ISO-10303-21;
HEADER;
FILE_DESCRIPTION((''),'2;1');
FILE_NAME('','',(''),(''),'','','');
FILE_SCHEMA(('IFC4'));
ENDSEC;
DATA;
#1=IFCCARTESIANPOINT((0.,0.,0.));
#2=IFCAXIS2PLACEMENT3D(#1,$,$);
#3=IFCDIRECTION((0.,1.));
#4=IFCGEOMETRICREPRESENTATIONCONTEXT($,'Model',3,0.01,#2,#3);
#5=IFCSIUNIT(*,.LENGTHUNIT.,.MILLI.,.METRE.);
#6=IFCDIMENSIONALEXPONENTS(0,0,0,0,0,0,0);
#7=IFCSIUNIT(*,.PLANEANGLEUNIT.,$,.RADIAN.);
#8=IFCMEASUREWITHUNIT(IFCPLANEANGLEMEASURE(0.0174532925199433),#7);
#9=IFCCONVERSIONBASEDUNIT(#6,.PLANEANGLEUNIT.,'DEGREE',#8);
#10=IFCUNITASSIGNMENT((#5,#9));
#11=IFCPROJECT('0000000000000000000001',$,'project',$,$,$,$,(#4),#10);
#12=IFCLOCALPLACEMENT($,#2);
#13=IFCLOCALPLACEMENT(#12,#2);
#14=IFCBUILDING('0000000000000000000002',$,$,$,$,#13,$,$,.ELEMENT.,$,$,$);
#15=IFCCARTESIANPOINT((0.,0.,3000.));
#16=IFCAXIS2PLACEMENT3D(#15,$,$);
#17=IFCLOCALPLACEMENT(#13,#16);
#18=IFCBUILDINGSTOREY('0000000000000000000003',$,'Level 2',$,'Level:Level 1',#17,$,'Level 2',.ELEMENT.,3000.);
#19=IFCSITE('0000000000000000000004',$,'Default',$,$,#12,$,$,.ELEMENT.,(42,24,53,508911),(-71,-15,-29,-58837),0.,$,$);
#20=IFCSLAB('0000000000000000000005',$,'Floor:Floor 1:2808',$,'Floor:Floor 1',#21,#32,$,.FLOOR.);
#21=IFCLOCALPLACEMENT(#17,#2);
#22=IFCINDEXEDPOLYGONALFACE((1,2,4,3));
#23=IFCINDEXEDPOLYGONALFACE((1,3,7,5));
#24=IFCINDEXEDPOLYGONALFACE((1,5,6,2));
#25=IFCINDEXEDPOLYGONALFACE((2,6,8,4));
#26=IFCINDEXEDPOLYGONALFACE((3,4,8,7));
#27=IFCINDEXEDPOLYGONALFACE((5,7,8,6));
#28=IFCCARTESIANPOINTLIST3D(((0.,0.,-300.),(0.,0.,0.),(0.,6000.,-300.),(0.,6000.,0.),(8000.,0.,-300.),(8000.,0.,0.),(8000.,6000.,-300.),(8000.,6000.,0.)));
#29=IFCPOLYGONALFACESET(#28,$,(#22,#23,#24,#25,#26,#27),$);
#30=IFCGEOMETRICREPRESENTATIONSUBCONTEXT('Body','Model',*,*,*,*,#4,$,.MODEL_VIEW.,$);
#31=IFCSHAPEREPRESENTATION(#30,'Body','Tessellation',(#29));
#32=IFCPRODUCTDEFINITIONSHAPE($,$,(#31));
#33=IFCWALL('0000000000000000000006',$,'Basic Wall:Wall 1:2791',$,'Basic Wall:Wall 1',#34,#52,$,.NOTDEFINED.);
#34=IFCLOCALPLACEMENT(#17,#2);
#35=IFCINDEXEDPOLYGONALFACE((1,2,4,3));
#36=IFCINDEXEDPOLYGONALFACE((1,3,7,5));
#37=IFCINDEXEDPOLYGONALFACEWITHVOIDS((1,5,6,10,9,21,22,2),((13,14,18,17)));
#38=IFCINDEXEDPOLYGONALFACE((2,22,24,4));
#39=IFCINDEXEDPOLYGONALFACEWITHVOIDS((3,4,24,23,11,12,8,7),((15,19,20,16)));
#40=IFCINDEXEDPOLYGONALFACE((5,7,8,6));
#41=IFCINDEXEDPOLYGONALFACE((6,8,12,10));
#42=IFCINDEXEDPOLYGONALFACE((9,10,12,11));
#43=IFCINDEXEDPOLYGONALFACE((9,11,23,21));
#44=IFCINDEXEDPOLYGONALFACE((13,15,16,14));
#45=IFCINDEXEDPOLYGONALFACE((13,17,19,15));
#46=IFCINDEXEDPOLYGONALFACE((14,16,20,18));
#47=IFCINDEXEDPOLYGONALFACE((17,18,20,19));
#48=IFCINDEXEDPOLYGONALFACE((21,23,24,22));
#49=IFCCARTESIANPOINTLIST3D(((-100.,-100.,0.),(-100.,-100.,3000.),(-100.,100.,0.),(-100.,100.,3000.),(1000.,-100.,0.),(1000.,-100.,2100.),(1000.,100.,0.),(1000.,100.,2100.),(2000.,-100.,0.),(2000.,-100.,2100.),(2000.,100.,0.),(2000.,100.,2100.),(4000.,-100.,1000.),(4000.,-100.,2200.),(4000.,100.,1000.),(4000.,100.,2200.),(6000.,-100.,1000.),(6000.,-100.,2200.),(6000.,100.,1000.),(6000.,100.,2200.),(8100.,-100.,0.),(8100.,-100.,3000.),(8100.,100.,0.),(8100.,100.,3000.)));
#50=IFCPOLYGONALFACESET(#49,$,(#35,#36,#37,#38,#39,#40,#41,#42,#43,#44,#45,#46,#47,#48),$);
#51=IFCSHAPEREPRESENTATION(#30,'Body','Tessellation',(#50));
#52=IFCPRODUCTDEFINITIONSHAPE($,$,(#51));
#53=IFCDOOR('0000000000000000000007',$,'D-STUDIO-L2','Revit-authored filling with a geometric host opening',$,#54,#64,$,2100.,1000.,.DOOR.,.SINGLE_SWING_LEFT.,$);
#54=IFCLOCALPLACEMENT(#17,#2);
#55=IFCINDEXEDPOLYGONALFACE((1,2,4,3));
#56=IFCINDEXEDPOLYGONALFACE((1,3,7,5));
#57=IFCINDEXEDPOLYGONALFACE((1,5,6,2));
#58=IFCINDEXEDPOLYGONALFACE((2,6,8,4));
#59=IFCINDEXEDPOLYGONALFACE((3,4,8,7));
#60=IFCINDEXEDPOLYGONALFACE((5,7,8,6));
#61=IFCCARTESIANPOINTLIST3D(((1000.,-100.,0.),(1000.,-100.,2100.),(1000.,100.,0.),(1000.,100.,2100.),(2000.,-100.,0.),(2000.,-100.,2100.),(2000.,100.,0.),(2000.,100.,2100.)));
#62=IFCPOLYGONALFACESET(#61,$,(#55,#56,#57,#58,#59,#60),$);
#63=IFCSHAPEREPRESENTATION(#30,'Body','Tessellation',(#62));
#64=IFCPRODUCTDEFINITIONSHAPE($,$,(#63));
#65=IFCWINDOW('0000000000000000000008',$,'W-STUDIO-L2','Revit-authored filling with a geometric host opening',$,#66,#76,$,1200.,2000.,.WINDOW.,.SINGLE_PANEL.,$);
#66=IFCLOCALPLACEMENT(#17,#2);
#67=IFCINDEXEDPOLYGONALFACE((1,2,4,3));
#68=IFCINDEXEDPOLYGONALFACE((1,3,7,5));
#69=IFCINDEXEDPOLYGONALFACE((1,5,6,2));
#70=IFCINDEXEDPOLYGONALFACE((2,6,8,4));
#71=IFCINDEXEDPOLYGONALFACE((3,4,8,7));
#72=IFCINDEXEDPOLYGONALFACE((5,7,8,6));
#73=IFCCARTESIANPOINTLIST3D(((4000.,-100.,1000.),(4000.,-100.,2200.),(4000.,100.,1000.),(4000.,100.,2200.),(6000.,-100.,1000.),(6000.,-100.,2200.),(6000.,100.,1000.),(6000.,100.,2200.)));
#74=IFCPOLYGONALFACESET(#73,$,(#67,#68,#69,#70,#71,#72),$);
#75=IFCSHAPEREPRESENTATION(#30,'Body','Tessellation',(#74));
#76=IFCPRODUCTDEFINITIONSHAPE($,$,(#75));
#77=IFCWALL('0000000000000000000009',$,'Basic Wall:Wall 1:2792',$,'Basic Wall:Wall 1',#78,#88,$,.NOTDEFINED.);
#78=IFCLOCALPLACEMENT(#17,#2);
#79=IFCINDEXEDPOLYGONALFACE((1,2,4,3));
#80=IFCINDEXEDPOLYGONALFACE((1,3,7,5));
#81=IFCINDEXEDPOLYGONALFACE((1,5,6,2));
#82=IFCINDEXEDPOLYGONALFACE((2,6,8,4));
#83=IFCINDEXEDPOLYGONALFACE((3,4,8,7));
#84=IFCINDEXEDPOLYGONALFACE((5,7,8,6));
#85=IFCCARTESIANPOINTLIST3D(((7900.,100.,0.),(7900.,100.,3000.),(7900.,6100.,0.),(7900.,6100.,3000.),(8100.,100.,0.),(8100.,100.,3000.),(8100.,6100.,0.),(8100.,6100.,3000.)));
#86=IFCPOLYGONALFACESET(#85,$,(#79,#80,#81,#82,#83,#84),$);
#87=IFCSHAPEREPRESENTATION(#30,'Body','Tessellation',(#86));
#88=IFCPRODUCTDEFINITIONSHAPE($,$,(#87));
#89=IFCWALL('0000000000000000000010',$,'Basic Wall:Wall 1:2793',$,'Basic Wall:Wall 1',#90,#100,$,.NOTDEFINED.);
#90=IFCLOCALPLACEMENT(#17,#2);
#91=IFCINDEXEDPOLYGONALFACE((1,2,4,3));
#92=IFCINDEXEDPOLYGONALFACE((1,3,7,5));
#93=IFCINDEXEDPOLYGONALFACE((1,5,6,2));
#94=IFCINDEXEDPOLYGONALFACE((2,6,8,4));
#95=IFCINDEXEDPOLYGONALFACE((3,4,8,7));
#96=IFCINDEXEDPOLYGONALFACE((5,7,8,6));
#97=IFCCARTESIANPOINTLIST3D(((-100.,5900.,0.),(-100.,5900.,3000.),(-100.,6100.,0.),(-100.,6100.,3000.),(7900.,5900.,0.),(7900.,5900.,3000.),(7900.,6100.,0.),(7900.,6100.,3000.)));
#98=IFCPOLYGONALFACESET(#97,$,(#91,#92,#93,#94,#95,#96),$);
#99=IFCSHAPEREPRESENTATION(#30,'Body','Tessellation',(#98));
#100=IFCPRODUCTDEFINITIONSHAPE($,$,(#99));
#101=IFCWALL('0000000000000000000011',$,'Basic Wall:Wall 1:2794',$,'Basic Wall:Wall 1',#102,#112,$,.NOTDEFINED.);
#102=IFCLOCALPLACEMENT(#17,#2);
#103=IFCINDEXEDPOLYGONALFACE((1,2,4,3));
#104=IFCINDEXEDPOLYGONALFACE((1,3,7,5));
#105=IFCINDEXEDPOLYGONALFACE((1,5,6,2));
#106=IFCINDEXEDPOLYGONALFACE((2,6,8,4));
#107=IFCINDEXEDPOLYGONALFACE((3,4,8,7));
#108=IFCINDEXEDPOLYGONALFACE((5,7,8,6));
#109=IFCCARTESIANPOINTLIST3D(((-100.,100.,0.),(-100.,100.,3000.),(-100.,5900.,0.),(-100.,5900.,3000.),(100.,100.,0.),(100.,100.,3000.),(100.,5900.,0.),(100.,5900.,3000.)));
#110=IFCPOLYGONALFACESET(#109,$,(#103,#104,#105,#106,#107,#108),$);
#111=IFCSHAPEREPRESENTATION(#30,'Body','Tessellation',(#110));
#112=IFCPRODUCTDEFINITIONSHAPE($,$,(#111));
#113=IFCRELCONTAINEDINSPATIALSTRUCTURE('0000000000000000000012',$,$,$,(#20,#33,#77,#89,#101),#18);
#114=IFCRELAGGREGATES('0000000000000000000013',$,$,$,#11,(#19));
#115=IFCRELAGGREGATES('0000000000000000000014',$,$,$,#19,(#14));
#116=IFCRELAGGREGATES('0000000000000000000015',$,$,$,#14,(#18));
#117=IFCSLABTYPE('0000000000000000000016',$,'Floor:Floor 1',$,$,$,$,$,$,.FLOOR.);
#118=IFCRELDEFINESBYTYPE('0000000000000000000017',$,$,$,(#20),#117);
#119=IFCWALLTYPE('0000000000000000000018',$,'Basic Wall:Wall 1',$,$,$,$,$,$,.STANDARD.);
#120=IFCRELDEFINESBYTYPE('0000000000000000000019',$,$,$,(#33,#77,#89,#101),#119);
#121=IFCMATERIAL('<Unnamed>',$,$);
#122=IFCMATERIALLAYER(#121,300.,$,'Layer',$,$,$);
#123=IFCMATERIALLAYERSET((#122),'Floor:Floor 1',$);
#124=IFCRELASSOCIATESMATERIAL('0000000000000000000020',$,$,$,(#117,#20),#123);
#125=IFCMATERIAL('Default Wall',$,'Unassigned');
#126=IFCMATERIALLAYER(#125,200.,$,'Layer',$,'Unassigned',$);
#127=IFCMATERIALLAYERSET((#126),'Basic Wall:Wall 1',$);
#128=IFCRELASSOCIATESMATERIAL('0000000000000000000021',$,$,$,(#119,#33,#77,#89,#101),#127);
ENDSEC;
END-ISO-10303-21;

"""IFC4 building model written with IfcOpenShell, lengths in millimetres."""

from ifc_helpers import new_model, entity, si_unit, converted_unit, direction, frame, frame_2d, origin, origin_2d, origin_2d_with_axis, place, context, subcontext, project, spatial, rectangle, extrude, material, layer, layer_set, layer_usage, type_object, element, fill, save


model = new_model("IFC4")

# Units and contexts
model_context = context("Model", 3, precision=0.01, world=origin(), true_north=direction((0.0, 1.0)))
body_context = subcontext(model_context, "Body", "Model", "MODEL_VIEW")
ifc_project = project(units=[si_unit("LENGTHUNIT", "METRE", prefix="MILLI"), converted_unit("PLANEANGLEUNIT", "DEGREE", entity("IfcPlaneAngleMeasure", 0.0174532925199433), si_unit("PLANEANGLEUNIT", "RADIAN"), dimensions=[0, 0, 0, 0, 0, 0, 0])], contexts=[model_context])

# Site, building, storey
site_placement = place(None, origin())
site = spatial("IfcSite", under=ifc_project, at=site_placement, Name="Default", CompositionType="ELEMENT", RefLatitude=(42, 24, 53, 508911), RefLongitude=(-71, -15, -29, -58837), RefElevation=0.0)
building_placement = place(site_placement, origin())
building = spatial("IfcBuilding", under=site, at=building_placement, CompositionType="ELEMENT")
storey_placement = place(building_placement, frame((0.0, 0.0, 3000.0)))
storey = spatial("IfcBuildingStorey", under=building, at=storey_placement, Name="Level 2", ObjectType="Level:Level 1", LongName="Level 2", CompositionType="ELEMENT", Elevation=3000.0)

# Slab
ifc_material_1 = material(Name="<Unnamed>")
ifc_layer_1 = layer(ifc_material_1, 300.0, Name="Layer")
ifc_layer_set_1 = layer_set([ifc_layer_1], Name="Floor:Floor 1")
ifc_layer_usage_1 = layer_usage(ifc_layer_set_1, "AXIS3", "POSITIVE", 0.0)
slab_type = type_object("IfcSlabType", Name="Floor:Floor 1", PredefinedType="FLOOR", material=ifc_layer_set_1)
slab_placement = place(storey_placement, origin())
element("IfcSlab", 1, at=slab_placement, inside=storey, type_object=slab_type, material=ifc_layer_usage_1, Name="Floor:Floor 1:2808", ObjectType="Floor:Floor 1", PredefinedType="FLOOR", context=body_context, shape_type="SweptSolid", body=[
    extrude(rectangle(XDim=6000.0, YDim=8000.0, at=origin_2d_with_axis()), frame((4000.0, 3000.0, 0.0), z_axis=(0.0, 0.0, -1.0), x_axis=(0.0, 1.0, 0.0)), (0.0, 0.0, 1.0), 300.0),
])

# Wall, openings, door, window
ifc_material_2 = material(Name="Default Wall", Category="Unassigned")
ifc_layer_2 = layer(ifc_material_2, 200.0, Name="Layer", Category="Unassigned")
ifc_layer_set_2 = layer_set([ifc_layer_2], Name="Basic Wall:Wall 1")
ifc_layer_usage_2 = layer_usage(ifc_layer_set_2, "AXIS2", "NEGATIVE", 100.0)
wall_type = type_object("IfcWallType", Name="Basic Wall:Wall 1", PredefinedType="STANDARD", material=ifc_layer_set_2)
wall_1_placement = place(storey_placement, frame((-100.0, 0.0, 0.0)))
wall_1 = element("IfcWall", 2, at=wall_1_placement, inside=storey, type_object=wall_type, material=ifc_layer_usage_2, Name="Basic Wall:Wall 1:2791", ObjectType="Basic Wall:Wall 1", PredefinedType="NOTDEFINED", context=body_context, shape_type="SweptSolid", body=[
    extrude(rectangle(XDim=8200.0, YDim=200.0, at=frame_2d((4100.0, 0.0), x_axis=(-1.0, 0.0))), origin(), (0.0, 0.0, 1.0), 3000.0),
])
opening_1_placement = place(storey_placement, frame((1000.0, -100.0, 0.0)))
opening_1 = element("IfcOpeningElement", 3, at=opening_1_placement, cuts=wall_1, PredefinedType="OPENING", context=body_context, shape_type="SweptSolid", body=[
    extrude(rectangle(XDim=1000.0, YDim=200.0, at=origin_2d()), frame((500.0, 100.0, 0.0)), (0.0, 0.0, 1.0), 2100.0),
])
opening_2_placement = place(storey_placement, frame((4000.0, -100.0, 1000.0)))
opening_2 = element("IfcOpeningElement", 4, at=opening_2_placement, cuts=wall_1, PredefinedType="OPENING", context=body_context, shape_type="SweptSolid", body=[
    extrude(rectangle(XDim=2000.0, YDim=200.0, at=origin_2d()), frame((1000.0, 100.0, 0.0)), (0.0, 0.0, 1.0), 1200.0),
])
door_placement = place(storey_placement, frame((1000.0, -100.0, 0.0)))
door = element("IfcDoor", 5, at=door_placement, Name="D-STUDIO-L2", Description="Revit-authored filling with a geometric host opening", OperationType="SINGLE_SWING_LEFT", OverallHeight=2100.0, OverallWidth=1000.0, PredefinedType="DOOR", context=body_context, shape_type="SweptSolid", body=[
    extrude(rectangle(XDim=1000.0, YDim=200.0, at=origin_2d()), frame((500.0, 100.0, 0.0)), (0.0, 0.0, 1.0), 2100.0),
])
fill(opening_1, door)
window_placement = place(storey_placement, frame((4000.0, -100.0, 1000.0)))
window = element("IfcWindow", 6, at=window_placement, Name="W-STUDIO-L2", Description="Revit-authored filling with a geometric host opening", OverallHeight=1200.0, OverallWidth=2000.0, PartitioningType="SINGLE_PANEL", PredefinedType="WINDOW", context=body_context, shape_type="SweptSolid", body=[
    extrude(rectangle(XDim=2000.0, YDim=200.0, at=origin_2d()), frame((1000.0, 100.0, 0.0)), (0.0, 0.0, 1.0), 1200.0),
])
fill(opening_2, window)

# Walls
ifc_layer_usage_3 = layer_usage(ifc_layer_set_2, "AXIS2", "NEGATIVE", 100.0)
wall_2_placement = place(storey_placement, frame((8000.0, 100.0, 0.0), z_axis=(0.0, 0.0, 1.0), x_axis=(0.0, 1.0, 0.0)))
element("IfcWall", 7, at=wall_2_placement, inside=storey, type_object=wall_type, material=ifc_layer_usage_3, Name="Basic Wall:Wall 1:2792", ObjectType="Basic Wall:Wall 1", PredefinedType="NOTDEFINED", context=body_context, shape_type="SweptSolid", body=[
    extrude(rectangle(XDim=6000.0, YDim=200.0, at=frame_2d((3000.0, 0.0), x_axis=(-1.0, 0.0))), origin(), (0.0, 0.0, 1.0), 3000.0),
])
ifc_layer_usage_4 = layer_usage(ifc_layer_set_2, "AXIS2", "NEGATIVE", 100.0)
wall_3_placement = place(storey_placement, frame((7900.0, 6000.0, 0.0), z_axis=(0.0, 0.0, 1.0), x_axis=(-1.0, 0.0, 0.0)))
element("IfcWall", 8, at=wall_3_placement, inside=storey, type_object=wall_type, material=ifc_layer_usage_4, Name="Basic Wall:Wall 1:2793", ObjectType="Basic Wall:Wall 1", PredefinedType="NOTDEFINED", context=body_context, shape_type="SweptSolid", body=[
    extrude(rectangle(XDim=8000.0, YDim=200.0, at=frame_2d((4000.0, 0.0), x_axis=(-1.0, 0.0))), origin(), (0.0, 0.0, 1.0), 3000.0),
])
ifc_layer_usage_5 = layer_usage(ifc_layer_set_2, "AXIS2", "NEGATIVE", 100.0)
wall_4_placement = place(storey_placement, frame((0.0, 5900.0, 0.0), z_axis=(0.0, 0.0, 1.0), x_axis=(0.0, -1.0, 0.0)))
element("IfcWall", 9, at=wall_4_placement, inside=storey, type_object=wall_type, material=ifc_layer_usage_5, Name="Basic Wall:Wall 1:2794", ObjectType="Basic Wall:Wall 1", PredefinedType="NOTDEFINED", context=body_context, shape_type="SweptSolid", body=[
    extrude(rectangle(XDim=5800.0, YDim=200.0, at=frame_2d((2900.0, 0.0), x_axis=(-1.0, 0.0))), origin(), (0.0, 0.0, 1.0), 3000.0),
])

save(model, "model.ifc")
